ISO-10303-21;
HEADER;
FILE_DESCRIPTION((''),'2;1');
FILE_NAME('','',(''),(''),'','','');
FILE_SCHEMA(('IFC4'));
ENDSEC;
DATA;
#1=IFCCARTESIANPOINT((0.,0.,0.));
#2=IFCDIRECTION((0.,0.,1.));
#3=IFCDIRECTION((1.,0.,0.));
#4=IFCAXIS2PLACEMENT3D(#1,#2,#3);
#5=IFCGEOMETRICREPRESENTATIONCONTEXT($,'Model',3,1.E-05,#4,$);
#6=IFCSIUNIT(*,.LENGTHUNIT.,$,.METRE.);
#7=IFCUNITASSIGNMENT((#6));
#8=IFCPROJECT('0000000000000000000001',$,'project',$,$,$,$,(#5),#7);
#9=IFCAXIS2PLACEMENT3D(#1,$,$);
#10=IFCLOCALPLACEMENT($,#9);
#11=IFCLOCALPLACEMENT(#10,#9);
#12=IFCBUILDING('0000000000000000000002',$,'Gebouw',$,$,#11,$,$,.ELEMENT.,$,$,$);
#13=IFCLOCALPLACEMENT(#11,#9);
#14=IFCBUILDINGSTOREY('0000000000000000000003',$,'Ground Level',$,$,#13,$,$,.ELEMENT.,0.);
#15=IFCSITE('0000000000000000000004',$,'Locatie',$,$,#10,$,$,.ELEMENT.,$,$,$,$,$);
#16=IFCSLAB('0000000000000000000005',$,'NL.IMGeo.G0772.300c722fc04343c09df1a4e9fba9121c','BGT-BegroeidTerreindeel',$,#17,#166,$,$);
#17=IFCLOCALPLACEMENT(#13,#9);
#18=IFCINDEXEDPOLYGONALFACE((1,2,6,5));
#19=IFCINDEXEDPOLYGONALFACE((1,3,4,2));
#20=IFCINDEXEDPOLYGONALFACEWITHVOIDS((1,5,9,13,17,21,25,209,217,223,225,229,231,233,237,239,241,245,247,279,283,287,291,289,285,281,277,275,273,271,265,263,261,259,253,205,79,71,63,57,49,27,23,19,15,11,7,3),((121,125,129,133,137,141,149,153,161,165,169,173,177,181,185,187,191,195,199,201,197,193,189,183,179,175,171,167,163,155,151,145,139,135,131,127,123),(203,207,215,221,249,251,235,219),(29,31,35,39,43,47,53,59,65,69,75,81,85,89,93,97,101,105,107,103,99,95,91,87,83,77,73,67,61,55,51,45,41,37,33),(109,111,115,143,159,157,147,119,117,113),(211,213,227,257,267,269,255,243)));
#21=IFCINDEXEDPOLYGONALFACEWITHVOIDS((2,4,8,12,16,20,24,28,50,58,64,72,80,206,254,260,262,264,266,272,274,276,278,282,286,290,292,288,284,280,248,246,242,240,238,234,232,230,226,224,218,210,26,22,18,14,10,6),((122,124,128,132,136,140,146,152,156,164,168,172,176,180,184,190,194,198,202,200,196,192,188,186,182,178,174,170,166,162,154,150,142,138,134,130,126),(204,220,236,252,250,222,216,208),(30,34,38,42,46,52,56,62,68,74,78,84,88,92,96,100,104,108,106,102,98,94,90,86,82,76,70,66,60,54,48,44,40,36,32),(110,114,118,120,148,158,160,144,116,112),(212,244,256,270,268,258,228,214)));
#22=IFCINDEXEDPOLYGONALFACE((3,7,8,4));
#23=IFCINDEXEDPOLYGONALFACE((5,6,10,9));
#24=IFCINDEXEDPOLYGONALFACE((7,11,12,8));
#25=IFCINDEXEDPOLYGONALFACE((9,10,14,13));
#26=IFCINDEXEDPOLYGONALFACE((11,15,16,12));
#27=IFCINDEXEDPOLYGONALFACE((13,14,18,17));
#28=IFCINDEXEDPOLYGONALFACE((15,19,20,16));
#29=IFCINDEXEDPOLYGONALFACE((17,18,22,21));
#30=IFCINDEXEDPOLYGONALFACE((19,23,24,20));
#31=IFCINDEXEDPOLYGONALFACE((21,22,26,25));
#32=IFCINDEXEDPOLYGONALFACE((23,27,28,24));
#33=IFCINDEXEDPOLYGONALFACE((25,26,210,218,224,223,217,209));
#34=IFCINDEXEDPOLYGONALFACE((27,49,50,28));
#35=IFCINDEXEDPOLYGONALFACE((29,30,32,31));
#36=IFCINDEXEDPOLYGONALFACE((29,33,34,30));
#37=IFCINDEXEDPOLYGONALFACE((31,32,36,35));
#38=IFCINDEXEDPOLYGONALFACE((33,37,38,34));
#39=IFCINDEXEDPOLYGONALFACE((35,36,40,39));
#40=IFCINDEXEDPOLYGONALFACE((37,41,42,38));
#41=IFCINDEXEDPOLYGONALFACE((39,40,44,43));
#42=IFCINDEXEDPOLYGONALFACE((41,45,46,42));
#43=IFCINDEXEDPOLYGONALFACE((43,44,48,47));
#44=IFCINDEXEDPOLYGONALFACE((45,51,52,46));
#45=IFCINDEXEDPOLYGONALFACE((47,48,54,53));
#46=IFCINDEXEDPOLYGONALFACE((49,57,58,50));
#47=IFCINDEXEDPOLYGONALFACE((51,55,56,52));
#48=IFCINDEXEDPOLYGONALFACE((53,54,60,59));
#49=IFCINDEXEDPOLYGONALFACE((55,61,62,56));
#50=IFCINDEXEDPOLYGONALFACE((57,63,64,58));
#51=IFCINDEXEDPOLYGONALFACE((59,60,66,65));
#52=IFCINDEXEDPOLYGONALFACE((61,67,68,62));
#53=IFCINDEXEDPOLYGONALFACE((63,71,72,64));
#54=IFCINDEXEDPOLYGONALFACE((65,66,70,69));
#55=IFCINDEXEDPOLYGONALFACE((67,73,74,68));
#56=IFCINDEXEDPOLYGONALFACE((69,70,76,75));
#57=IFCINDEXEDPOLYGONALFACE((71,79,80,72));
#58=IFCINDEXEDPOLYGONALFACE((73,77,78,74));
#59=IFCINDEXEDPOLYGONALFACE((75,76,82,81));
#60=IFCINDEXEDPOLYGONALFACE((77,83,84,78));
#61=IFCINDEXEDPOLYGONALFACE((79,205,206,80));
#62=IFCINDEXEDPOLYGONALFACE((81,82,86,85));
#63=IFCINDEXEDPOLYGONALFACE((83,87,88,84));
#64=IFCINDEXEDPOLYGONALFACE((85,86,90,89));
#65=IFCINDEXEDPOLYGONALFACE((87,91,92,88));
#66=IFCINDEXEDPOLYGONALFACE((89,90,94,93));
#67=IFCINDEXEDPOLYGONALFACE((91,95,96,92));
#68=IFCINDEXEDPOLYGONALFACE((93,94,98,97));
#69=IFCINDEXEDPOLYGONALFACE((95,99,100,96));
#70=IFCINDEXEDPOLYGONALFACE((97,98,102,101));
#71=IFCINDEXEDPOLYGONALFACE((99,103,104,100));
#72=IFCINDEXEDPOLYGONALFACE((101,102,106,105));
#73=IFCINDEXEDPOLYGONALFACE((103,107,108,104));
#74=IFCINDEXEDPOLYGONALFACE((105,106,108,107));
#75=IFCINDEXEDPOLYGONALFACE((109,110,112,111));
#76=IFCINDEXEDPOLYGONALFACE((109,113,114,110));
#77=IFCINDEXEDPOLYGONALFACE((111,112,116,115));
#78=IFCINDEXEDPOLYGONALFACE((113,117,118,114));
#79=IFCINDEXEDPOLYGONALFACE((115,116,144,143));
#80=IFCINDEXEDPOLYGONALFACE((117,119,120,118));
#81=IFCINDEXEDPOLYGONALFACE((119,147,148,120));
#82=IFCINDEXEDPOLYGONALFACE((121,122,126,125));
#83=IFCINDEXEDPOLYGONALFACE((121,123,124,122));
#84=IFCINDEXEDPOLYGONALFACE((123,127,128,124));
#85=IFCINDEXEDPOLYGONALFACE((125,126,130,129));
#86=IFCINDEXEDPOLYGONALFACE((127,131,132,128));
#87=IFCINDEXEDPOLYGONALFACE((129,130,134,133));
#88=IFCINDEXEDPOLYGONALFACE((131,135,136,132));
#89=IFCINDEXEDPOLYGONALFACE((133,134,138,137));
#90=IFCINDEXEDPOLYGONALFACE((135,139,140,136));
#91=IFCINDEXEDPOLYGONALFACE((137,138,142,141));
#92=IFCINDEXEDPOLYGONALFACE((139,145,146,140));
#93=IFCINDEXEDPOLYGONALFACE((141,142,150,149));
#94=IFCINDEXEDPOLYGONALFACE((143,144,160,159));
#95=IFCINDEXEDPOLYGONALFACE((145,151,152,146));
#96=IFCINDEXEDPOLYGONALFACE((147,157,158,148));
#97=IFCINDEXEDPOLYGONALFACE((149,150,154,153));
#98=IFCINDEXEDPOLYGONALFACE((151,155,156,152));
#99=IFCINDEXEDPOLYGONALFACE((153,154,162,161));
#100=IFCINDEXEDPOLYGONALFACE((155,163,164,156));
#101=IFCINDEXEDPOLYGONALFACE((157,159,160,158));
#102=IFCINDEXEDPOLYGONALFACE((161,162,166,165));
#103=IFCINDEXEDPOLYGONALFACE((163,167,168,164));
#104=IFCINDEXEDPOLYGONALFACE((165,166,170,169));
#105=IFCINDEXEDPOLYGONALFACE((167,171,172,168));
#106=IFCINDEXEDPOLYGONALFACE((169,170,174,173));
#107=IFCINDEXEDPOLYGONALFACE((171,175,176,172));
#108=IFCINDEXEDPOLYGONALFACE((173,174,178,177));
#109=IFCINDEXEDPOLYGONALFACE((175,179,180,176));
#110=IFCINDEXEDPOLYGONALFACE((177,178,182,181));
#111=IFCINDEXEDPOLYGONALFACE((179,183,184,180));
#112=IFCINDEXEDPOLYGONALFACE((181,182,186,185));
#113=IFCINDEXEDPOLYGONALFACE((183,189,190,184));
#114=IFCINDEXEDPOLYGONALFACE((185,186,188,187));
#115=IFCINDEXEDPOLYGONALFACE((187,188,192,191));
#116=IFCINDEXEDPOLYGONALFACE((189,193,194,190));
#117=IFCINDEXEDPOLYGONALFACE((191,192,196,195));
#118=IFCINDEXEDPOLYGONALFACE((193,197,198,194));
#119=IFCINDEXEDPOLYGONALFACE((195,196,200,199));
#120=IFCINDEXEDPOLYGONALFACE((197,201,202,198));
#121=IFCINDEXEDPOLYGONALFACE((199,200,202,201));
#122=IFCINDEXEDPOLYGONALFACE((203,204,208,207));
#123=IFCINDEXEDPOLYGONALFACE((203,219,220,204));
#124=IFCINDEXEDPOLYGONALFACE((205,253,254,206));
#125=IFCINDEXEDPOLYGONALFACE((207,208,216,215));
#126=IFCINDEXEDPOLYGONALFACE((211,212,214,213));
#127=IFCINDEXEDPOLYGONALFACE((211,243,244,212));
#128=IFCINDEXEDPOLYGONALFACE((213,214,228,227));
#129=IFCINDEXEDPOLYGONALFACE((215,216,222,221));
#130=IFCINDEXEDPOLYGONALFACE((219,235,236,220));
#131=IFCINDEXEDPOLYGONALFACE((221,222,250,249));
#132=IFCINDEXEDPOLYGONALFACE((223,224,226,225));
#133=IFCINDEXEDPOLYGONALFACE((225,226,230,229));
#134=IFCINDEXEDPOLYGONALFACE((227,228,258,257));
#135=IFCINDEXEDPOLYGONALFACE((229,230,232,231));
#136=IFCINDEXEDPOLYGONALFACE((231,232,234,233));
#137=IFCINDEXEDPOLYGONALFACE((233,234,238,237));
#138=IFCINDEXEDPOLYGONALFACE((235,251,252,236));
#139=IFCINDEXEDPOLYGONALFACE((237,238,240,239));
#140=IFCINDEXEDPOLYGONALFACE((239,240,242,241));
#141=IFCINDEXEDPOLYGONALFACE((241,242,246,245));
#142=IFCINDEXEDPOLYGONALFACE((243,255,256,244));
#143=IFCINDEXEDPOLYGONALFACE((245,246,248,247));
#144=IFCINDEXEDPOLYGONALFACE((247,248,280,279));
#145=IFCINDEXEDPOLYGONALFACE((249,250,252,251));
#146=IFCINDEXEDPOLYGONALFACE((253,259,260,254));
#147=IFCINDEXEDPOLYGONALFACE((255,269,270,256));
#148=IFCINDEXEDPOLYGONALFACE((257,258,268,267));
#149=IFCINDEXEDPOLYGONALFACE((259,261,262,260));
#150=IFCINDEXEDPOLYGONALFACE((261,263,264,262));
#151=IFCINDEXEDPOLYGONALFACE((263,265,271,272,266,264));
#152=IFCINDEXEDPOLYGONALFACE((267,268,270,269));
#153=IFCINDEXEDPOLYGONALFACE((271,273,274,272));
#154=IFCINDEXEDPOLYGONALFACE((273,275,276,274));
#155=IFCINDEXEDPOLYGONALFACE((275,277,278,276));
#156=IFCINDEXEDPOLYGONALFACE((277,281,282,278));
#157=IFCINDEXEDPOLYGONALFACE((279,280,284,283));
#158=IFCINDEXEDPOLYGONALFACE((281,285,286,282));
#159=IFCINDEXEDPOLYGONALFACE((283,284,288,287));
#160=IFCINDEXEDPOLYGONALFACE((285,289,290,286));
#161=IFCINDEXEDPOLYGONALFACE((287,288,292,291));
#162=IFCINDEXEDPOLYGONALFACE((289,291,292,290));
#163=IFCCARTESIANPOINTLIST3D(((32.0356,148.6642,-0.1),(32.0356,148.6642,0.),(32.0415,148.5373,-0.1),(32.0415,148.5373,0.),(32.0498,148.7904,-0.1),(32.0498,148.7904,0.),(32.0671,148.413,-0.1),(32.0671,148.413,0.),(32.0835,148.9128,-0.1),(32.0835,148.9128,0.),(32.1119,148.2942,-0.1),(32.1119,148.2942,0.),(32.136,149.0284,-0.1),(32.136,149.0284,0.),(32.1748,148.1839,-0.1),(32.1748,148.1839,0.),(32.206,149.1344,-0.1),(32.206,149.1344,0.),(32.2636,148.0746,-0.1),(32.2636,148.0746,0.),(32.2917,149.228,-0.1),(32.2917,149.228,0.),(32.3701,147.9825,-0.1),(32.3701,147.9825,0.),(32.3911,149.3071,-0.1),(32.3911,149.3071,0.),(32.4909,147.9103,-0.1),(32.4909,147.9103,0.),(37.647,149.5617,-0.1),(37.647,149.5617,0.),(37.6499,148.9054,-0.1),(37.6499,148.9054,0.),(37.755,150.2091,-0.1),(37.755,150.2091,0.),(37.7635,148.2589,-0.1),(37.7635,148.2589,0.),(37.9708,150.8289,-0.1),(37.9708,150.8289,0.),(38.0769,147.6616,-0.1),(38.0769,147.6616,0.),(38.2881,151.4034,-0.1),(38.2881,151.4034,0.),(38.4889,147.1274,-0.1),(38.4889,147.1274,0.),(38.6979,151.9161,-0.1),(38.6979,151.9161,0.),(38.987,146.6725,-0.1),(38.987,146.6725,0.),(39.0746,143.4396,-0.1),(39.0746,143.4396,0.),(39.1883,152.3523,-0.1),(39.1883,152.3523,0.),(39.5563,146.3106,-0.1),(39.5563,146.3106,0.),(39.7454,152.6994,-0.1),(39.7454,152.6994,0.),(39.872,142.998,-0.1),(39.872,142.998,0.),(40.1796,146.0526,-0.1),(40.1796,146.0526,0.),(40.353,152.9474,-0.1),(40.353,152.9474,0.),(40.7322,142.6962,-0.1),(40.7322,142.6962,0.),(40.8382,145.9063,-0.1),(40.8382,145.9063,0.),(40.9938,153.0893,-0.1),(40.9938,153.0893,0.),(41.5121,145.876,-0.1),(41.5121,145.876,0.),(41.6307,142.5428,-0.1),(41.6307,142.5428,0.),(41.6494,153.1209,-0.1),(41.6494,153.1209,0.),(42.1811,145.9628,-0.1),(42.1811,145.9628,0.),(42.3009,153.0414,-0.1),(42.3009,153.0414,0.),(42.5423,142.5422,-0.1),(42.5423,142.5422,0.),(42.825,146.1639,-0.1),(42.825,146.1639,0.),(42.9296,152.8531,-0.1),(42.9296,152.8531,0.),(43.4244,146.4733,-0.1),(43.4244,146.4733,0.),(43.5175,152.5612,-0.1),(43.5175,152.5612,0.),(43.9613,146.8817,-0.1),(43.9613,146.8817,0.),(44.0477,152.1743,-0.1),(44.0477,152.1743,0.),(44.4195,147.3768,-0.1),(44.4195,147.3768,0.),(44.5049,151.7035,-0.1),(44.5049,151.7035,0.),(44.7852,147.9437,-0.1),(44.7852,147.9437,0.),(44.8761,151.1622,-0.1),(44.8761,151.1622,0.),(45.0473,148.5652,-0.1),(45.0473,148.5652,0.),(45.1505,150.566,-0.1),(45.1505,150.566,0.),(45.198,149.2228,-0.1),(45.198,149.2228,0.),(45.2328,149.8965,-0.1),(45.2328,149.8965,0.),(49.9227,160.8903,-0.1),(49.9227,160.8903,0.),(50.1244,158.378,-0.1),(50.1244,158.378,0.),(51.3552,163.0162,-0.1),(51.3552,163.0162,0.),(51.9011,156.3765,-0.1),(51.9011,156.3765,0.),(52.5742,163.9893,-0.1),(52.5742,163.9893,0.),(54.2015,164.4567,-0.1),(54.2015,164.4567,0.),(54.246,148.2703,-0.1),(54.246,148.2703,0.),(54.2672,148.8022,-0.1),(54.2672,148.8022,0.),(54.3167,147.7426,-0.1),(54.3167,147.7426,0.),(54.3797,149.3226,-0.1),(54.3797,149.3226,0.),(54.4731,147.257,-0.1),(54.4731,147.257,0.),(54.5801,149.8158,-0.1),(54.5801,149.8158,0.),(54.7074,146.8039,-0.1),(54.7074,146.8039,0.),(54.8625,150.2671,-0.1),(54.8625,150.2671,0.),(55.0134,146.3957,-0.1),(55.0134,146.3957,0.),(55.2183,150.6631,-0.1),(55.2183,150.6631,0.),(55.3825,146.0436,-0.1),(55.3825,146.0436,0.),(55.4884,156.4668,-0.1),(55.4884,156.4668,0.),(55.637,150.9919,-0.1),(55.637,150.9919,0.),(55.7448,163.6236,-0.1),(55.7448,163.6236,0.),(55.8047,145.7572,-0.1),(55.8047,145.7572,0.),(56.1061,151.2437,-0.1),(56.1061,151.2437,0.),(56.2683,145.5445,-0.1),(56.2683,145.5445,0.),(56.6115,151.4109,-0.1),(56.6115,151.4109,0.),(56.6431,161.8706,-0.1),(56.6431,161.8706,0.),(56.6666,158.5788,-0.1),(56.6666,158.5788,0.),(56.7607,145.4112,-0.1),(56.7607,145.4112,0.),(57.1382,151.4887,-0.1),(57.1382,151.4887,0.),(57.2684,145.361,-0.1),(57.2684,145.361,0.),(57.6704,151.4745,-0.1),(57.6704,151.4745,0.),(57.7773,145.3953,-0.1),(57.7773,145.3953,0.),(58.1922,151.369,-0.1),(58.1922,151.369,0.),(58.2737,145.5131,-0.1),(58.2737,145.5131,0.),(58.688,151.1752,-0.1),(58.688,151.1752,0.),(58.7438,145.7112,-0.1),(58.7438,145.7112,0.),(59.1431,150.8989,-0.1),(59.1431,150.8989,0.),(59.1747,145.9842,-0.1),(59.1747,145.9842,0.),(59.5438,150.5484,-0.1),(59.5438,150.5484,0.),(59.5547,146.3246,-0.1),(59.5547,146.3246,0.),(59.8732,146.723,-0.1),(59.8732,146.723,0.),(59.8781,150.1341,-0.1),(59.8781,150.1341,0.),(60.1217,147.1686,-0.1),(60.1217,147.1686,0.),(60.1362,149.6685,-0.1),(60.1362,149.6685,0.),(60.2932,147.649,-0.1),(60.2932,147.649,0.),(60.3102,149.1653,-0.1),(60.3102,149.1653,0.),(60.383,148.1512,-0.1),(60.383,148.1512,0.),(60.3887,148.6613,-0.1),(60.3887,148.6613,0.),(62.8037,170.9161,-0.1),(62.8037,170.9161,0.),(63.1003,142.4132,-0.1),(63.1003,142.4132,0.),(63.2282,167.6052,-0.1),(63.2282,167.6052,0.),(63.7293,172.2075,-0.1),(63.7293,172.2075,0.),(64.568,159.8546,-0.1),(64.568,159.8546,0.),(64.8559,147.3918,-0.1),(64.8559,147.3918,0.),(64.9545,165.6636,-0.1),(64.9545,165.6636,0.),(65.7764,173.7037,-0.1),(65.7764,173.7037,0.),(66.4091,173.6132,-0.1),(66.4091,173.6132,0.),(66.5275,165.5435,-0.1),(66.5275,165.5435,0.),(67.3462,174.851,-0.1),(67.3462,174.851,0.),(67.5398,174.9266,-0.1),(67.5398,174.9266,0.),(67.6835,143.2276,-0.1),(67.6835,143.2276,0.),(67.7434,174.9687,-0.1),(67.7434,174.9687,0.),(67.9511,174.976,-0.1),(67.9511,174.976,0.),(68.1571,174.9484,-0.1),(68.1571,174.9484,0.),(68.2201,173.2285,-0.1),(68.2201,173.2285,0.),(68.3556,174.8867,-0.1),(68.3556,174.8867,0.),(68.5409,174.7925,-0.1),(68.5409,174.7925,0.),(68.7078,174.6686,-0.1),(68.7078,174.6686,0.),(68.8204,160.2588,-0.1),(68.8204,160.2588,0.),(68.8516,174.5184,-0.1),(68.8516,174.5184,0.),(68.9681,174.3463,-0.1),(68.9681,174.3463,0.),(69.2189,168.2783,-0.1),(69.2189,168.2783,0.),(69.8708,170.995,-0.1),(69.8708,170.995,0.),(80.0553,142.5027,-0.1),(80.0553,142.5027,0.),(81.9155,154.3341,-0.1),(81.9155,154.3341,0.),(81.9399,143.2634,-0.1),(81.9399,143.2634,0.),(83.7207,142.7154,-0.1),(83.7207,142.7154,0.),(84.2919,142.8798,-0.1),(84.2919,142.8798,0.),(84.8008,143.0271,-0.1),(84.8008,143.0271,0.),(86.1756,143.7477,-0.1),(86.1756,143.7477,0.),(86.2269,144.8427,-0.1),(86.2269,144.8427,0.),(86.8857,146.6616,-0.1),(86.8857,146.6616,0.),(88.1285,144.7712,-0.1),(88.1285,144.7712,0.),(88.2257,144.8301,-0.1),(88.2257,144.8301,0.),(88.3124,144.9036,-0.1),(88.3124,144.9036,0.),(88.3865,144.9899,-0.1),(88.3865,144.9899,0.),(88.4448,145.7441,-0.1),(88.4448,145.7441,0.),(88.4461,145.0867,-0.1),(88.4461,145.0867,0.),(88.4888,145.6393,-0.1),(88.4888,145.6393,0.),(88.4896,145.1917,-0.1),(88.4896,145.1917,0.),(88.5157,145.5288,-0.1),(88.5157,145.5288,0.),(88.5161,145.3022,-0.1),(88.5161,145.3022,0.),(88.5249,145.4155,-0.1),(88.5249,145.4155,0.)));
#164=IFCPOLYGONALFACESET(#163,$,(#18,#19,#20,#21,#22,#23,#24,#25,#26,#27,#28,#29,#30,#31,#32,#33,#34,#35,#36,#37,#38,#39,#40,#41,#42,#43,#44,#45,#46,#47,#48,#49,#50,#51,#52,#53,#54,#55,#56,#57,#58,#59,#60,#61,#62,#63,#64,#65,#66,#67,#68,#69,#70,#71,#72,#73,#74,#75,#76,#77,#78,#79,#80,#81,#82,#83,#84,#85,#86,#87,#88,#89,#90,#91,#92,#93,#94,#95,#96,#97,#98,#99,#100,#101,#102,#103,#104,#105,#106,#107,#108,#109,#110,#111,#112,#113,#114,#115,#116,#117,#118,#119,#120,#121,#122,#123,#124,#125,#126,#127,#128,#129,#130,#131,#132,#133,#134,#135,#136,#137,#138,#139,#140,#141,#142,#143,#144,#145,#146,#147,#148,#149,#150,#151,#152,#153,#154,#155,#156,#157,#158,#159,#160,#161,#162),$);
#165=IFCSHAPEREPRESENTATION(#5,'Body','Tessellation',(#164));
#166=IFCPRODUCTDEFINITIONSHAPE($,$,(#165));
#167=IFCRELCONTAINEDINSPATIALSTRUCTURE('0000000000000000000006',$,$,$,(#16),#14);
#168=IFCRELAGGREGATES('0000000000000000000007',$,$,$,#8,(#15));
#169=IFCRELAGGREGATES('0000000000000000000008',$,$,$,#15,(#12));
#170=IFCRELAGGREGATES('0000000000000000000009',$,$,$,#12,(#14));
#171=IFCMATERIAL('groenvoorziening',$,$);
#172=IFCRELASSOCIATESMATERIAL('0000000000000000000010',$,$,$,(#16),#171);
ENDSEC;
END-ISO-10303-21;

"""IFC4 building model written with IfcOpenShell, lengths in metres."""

from ifc_helpers import new_model, si_unit, frame, origin, origin_with_axes, place, context, project, spatial, polyline, outline, extrude, material, element, save


model = new_model("IFC4")

# Units and contexts
model_context = context("Model", 3, precision=1e-05, world=origin_with_axes())
ifc_project = project(units=[si_unit("LENGTHUNIT", "METRE")], contexts=[model_context])

# Site, building, storey
site_placement = place(None, origin())
site = spatial("IfcSite", under=ifc_project, at=site_placement, Name="Locatie", CompositionType="ELEMENT")
building_placement = place(site_placement, origin())
building = spatial("IfcBuilding", under=site, at=building_placement, Name="Gebouw", CompositionType="ELEMENT")
storey_placement = place(building_placement, origin())
storey = spatial("IfcBuildingStorey", under=building, at=storey_placement, Name="Ground Level", CompositionType="ELEMENT", Elevation=0.0)

# Slab
ifc_material = material(Name="groenvoorziening")
slab_1_placement = place(storey_placement, origin())
element("IfcSlab", 1, at=slab_1_placement, inside=storey, material=ifc_material, Name="NL.IMGeo.G0772.300c722fc04343c09df1a4e9fba9121c", Description="BGT-BegroeidTerreindeel", context=model_context, shape_type="SweptSolid", body=[
    extrude(outline(polyline([(88.4448, 145.7441), (88.4888, 145.6393), (88.5157, 145.5288), (88.5249, 145.4155), (88.5161, 145.3022), (88.4896, 145.1917), (88.4461, 145.0867), (88.3865, 144.9899), (88.3124, 144.9036), (88.2257, 144.8301), (88.1285, 144.7712), (86.1756, 143.7477), (84.8008, 143.0271), (84.2919, 142.8798), (83.7207, 142.7154), (80.0553, 142.5027), (63.1003, 142.4132), (42.5423, 142.5422), (41.6307, 142.5428), (40.7322, 142.6962), (39.872, 142.998), (39.0746, 143.4396), (32.4909, 147.9103), (32.3701, 147.9825), (32.2636, 148.0746), (32.1748, 148.1839), (32.1119, 148.2942), (32.0671, 148.413), (32.0415, 148.5373), (32.0356, 148.6642), (32.0498, 148.7904), (32.0835, 148.9128), (32.136, 149.0284), (32.206, 149.1344), (32.2917, 149.228), (32.3911, 149.3071), (63.7293, 172.2075), (65.7764, 173.7037), (67.3462, 174.851), (67.5398, 174.9266), (67.7434, 174.9687), (67.9511, 174.976), (68.1571, 174.9484), (68.3556, 174.8867), (68.5409, 174.7925), (68.7078, 174.6686), (68.8516, 174.5184), (68.9681, 174.3463), (88.4448, 145.7441)]), holes=[polyline([(54.4731, 147.257), (54.7074, 146.8039), (55.0134, 146.3957), (55.3825, 146.0436), (55.8047, 145.7572), (56.2683, 145.5445), (56.7607, 145.4112), (57.2684, 145.361), (57.7773, 145.3953), (58.2737, 145.5131), (58.7438, 145.7112), (59.1747, 145.9842), (59.5547, 146.3246), (59.8732, 146.723), (60.1217, 147.1686), (60.2932, 147.649), (60.383, 148.1512), (60.3887, 148.6613), (60.3102, 149.1653), (60.1362, 149.6685), (59.8781, 150.1341), (59.5438, 150.5484), (59.1431, 150.8989), (58.688, 151.1752), (58.1922, 151.369), (57.6704, 151.4745), (57.1382, 151.4887), (56.6115, 151.4109), (56.1061, 151.2437), (55.637, 150.9919), (55.2183, 150.6631), (54.8625, 150.2671), (54.5801, 149.8158), (54.3797, 149.3226), (54.2672, 148.8022), (54.246, 148.2703), (54.3167, 147.7426), (54.4731, 147.257)]), polyline([(66.4091, 173.6132), (62.8037, 170.9161), (63.2282, 167.6052), (64.9545, 165.6636), (66.5275, 165.5435), (69.2189, 168.2783), (69.8708, 170.995), (68.2201, 173.2285), (66.4091, 173.6132)]), polyline([(51.3552, 163.0162), (49.9227, 160.8903), (50.1244, 158.378), (51.9011, 156.3765), (55.4884, 156.4668), (56.6666, 158.5788), (56.6431, 161.8706), (55.7448, 163.6236), (54.2015, 164.4567), (52.5742, 163.9893), (51.3552, 163.0162)]), polyline([(44.8761, 151.1622), (44.5049, 151.7035), (44.0477, 152.1743), (43.5175, 152.5612), (42.9296, 152.8531), (42.3009, 153.0414), (41.6494, 153.1209), (40.9938, 153.0893), (40.353, 152.9474), (39.7454, 152.6994), (39.1883, 152.3523), (38.6979, 151.9161), (38.2881, 151.4034), (37.9708, 150.8289), (37.755, 150.2091), (37.647, 149.5617), (37.6499, 148.9054), (37.7635, 148.2589), (38.0769, 147.6616), (38.4889, 147.1274), (38.987, 146.6725), (39.5563, 146.3106), (40.1796, 146.0526), (40.8382, 145.9063), (41.5121, 145.876), (42.1811, 145.9628), (42.825, 146.1639), (43.4244, 146.4733), (43.9613, 146.8817), (44.4195, 147.3768), (44.7852, 147.9437), (45.0473, 148.5652), (45.198, 149.2228), (45.2328, 149.8965), (45.1505, 150.566), (44.8761, 151.1622)]), polyline([(68.8204, 160.2588), (64.568, 159.8546), (64.8559, 147.3918), (67.6835, 143.2276), (81.9399, 143.2634), (86.2269, 144.8427), (86.8857, 146.6616), (81.9155, 154.3341), (68.8204, 160.2588)])]), frame((0.0, 0.0, -0.1), z_axis=(0.0, 0.0, 1.0), x_axis=(1.0, 0.0, 0.0)), (0.0, 0.0, 1.0), 0.1),
])

save(model, "model.ifc")
